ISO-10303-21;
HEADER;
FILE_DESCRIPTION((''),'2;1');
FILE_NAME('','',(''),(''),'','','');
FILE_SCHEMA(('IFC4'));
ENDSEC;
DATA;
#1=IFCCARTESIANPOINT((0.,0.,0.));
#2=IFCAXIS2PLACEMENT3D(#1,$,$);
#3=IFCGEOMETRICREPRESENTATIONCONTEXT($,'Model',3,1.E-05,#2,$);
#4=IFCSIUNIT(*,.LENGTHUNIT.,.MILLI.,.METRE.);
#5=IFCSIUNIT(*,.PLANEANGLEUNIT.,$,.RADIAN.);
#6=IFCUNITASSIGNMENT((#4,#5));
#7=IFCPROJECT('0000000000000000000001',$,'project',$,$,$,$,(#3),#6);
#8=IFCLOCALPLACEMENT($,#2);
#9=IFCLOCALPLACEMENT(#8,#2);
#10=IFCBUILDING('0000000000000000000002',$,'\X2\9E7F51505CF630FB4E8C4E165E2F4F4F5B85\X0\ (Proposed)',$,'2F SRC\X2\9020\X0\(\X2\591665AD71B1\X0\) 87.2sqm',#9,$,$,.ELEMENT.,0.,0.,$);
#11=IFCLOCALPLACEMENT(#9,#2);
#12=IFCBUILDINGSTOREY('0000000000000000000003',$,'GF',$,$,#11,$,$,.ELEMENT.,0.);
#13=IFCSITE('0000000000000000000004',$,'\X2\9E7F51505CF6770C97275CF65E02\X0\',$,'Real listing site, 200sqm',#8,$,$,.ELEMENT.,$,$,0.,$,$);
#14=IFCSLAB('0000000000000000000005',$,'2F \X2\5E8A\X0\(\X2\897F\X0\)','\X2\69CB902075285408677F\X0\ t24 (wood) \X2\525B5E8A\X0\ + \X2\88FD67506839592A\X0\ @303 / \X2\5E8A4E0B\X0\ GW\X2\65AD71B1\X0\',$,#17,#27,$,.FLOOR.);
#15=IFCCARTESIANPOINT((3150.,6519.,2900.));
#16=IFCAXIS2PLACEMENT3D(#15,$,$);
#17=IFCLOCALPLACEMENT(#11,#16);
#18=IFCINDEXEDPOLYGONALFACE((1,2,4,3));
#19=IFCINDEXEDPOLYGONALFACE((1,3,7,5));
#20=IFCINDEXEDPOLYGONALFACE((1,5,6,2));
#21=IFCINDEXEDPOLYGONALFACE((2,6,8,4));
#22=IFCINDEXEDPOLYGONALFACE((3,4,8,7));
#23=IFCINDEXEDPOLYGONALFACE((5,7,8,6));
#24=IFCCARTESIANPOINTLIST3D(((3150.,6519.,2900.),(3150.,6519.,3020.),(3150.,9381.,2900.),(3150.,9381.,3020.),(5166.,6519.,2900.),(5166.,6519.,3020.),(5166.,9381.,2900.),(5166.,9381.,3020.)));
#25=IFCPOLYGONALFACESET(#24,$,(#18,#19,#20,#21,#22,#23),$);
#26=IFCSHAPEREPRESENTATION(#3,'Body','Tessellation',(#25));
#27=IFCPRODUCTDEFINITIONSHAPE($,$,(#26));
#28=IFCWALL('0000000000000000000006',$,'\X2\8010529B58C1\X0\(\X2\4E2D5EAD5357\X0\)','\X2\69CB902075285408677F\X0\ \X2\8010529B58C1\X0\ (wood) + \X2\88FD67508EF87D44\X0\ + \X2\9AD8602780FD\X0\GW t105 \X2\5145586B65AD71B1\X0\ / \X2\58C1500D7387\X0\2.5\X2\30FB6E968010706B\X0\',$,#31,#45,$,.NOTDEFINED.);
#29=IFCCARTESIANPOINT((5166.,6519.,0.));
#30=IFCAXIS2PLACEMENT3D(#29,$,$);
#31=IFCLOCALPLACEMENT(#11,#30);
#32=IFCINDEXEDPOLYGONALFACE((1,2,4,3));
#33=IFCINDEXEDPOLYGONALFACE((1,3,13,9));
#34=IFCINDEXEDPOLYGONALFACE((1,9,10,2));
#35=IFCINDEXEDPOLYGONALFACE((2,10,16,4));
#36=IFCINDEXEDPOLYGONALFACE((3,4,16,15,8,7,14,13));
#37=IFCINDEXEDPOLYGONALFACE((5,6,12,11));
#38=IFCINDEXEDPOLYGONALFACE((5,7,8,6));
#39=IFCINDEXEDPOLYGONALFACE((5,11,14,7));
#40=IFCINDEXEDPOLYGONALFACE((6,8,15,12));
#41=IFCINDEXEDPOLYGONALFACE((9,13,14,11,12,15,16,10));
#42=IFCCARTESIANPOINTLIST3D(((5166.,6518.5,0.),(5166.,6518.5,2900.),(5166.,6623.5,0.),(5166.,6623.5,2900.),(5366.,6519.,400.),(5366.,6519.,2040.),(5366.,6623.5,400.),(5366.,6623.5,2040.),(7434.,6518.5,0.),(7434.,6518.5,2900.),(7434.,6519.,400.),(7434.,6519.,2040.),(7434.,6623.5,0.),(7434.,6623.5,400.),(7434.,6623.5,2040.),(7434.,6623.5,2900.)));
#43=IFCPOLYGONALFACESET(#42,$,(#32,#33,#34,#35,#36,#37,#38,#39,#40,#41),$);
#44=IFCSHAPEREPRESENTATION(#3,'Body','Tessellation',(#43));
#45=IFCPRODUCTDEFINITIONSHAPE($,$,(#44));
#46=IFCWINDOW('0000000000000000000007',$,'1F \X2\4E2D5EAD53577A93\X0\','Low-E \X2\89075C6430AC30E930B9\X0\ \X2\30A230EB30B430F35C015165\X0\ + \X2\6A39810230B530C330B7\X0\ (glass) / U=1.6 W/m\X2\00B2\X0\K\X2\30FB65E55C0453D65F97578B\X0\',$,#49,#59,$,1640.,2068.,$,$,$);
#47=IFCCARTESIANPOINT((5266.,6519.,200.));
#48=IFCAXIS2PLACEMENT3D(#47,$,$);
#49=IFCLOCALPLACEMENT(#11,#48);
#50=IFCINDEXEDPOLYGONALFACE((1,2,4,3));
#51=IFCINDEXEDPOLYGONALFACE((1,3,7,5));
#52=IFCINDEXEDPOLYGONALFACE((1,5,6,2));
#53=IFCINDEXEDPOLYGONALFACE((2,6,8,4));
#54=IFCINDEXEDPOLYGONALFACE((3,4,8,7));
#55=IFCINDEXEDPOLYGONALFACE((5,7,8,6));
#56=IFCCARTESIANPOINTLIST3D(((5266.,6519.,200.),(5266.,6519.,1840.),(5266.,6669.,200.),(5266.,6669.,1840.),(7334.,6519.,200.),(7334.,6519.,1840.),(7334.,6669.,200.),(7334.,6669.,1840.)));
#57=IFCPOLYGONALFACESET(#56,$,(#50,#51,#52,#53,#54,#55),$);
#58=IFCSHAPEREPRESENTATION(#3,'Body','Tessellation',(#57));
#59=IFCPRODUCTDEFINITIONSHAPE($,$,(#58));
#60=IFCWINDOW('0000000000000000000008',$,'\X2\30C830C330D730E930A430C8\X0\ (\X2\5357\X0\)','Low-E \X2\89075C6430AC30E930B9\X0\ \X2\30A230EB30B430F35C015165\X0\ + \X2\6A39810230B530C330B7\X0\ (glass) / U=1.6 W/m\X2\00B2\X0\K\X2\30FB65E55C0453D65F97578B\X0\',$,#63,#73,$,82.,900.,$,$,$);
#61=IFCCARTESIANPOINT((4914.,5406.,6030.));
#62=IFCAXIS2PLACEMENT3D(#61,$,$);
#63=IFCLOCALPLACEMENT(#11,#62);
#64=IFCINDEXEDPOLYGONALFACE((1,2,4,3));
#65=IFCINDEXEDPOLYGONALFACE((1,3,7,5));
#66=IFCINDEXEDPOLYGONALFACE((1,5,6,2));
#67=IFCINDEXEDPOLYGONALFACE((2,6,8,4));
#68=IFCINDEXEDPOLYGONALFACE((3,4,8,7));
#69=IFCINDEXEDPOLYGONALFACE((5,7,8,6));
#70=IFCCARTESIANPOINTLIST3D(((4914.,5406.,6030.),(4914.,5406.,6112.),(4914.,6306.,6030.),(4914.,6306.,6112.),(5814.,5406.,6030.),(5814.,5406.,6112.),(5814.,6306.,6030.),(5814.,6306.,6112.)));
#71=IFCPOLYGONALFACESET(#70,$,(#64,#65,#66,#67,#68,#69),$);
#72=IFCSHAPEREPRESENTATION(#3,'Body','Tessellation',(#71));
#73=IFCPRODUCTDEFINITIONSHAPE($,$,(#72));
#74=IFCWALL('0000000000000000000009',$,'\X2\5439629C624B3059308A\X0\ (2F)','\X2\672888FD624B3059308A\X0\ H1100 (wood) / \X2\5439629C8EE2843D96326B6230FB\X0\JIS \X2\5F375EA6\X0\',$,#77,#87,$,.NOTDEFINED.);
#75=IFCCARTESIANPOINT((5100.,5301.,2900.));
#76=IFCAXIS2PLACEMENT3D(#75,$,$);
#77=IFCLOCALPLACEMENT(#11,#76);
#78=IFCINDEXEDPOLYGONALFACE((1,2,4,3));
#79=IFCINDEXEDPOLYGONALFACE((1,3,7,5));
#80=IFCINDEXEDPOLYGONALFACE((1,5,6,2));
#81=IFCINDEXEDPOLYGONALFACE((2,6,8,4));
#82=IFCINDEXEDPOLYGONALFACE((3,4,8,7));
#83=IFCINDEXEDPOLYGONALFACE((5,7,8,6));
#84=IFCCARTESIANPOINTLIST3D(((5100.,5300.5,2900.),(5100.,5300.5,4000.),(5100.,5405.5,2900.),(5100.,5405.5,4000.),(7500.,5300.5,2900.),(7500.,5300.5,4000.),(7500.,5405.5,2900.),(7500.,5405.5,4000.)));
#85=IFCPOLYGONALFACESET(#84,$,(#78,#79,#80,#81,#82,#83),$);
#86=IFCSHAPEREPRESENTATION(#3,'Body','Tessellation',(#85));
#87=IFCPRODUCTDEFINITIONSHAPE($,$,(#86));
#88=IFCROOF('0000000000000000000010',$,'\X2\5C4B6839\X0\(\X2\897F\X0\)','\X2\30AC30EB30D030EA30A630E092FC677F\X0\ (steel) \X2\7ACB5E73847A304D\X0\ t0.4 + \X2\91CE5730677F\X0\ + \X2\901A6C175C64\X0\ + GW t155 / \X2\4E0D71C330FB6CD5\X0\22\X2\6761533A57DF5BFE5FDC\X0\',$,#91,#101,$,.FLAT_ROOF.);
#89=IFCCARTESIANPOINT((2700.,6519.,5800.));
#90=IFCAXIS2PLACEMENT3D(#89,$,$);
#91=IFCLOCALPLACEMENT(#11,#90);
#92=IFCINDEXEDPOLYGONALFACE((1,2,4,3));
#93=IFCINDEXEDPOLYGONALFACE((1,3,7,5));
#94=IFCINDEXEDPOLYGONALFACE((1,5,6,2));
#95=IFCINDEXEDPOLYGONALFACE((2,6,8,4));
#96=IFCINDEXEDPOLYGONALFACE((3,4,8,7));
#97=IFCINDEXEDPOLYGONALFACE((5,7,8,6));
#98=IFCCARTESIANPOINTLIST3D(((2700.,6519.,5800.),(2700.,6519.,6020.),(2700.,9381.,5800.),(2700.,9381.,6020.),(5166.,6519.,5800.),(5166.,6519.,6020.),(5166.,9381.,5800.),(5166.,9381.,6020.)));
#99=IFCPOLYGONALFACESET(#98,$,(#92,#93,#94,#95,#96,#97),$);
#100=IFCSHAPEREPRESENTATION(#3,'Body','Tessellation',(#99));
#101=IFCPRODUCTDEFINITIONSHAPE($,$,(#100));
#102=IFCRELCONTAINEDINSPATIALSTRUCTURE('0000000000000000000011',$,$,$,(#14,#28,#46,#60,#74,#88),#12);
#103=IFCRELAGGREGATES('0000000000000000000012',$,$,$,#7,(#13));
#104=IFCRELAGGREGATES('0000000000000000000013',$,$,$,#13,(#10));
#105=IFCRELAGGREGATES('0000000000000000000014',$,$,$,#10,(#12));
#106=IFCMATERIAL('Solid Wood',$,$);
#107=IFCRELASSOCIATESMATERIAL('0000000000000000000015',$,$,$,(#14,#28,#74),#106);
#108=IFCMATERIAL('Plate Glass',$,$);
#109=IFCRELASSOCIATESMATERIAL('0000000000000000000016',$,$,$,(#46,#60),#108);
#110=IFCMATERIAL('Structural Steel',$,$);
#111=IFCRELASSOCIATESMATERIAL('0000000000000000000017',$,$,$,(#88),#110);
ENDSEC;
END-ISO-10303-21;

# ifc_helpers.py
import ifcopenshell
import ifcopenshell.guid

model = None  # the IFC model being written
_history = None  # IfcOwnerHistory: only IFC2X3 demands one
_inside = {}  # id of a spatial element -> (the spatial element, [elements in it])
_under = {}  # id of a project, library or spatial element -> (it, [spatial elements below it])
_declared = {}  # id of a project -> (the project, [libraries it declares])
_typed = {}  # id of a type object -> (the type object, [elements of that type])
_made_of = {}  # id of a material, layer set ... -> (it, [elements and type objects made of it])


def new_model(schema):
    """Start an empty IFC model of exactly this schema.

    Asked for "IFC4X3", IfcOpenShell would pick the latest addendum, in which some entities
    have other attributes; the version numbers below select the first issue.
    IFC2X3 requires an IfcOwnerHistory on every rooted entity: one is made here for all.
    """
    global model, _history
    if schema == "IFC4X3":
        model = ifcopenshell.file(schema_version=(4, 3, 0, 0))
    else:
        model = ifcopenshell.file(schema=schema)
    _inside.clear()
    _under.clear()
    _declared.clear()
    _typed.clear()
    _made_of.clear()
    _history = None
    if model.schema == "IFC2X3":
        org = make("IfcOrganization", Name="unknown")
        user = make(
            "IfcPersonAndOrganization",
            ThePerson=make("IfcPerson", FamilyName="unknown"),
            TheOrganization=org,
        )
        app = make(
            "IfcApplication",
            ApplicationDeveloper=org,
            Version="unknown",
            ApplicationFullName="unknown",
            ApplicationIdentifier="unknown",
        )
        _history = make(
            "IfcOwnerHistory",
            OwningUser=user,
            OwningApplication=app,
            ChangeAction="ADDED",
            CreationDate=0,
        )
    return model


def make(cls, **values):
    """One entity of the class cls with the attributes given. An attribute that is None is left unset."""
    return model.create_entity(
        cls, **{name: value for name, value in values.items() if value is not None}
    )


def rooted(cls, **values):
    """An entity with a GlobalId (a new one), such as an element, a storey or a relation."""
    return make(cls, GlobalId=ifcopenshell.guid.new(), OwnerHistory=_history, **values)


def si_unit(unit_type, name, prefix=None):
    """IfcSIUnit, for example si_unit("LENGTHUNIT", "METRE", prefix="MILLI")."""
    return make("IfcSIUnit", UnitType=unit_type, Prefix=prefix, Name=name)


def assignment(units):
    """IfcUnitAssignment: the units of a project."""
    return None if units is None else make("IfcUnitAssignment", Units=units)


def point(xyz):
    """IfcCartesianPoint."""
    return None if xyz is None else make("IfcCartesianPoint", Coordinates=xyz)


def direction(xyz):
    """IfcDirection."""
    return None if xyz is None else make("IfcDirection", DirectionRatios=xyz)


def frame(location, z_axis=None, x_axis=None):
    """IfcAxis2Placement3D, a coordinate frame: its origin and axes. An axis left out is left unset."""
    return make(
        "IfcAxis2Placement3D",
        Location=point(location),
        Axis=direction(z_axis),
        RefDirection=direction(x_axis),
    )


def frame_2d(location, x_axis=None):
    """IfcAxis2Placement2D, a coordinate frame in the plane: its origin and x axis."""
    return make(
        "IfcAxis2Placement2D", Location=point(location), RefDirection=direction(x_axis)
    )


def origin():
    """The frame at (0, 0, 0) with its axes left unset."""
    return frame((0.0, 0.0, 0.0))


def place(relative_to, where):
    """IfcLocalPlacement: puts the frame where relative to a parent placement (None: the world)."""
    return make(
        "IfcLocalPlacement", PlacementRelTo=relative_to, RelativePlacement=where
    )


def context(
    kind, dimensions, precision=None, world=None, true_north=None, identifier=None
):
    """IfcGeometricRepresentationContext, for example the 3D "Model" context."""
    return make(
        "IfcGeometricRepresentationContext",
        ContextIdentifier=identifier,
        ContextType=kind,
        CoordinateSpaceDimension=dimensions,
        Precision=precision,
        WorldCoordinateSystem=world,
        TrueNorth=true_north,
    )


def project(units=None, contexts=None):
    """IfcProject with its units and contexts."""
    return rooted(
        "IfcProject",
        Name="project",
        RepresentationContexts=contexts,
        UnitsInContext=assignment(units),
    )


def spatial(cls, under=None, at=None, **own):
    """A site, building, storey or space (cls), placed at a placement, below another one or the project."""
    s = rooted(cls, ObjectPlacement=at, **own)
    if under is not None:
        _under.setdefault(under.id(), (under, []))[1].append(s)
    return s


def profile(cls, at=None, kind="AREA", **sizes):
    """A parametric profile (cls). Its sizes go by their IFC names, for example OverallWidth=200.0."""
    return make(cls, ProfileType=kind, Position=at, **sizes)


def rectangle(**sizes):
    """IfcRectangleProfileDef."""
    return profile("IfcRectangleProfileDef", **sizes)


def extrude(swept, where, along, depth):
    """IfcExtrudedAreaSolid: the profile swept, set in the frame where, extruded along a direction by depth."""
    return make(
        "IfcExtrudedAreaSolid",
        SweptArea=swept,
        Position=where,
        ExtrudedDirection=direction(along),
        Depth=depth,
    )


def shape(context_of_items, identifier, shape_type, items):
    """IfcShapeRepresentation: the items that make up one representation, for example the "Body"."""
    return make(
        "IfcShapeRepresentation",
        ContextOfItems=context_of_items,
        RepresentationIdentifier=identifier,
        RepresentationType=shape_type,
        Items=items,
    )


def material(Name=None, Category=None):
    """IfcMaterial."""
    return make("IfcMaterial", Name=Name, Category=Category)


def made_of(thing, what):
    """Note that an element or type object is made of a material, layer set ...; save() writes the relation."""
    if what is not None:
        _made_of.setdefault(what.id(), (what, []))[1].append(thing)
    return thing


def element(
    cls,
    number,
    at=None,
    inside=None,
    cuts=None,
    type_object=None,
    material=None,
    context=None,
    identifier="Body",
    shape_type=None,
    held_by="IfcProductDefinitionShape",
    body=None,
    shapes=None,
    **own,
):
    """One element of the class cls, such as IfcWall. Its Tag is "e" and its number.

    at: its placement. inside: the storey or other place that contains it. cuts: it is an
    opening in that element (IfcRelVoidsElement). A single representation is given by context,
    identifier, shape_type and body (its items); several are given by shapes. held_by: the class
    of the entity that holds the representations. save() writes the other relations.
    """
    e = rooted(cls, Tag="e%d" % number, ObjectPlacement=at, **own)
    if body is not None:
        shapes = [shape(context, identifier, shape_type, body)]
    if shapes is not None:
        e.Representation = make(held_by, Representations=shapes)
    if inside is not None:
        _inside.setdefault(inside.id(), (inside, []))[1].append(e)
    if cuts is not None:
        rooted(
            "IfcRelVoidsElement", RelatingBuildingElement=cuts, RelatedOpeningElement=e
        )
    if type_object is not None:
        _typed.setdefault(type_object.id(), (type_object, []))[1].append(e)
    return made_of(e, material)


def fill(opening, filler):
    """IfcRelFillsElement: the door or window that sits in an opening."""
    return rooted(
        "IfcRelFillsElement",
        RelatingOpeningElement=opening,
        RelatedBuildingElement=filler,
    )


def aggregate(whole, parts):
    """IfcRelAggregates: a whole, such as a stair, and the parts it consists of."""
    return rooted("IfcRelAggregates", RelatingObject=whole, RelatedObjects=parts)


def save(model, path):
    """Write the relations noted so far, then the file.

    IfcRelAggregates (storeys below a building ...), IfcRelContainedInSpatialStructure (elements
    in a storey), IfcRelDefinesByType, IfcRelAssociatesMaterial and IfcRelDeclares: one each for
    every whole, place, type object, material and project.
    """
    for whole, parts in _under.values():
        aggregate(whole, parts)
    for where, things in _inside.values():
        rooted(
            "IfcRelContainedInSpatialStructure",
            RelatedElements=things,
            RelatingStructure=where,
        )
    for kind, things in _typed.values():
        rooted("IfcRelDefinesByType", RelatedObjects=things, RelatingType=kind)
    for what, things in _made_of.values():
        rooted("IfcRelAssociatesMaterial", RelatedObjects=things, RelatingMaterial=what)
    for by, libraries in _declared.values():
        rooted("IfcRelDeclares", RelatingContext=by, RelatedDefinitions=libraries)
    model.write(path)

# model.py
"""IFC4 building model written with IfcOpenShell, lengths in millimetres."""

from ifc_helpers import new_model, si_unit, frame, frame_2d, origin, place, context, project, spatial, rectangle, extrude, material, element, fill, save


model = new_model("IFC4")

# Units and contexts
model_context = context("Model", 3, precision=1e-05, world=origin())
ifc_project = project(units=[si_unit("LENGTHUNIT", "METRE", prefix="MILLI"), si_unit("PLANEANGLEUNIT", "RADIAN")], contexts=[model_context])

# Site, building, storey
site_placement = place(None, origin())
site = spatial("IfcSite", under=ifc_project, at=site_placement, Name="鹿児島県霧島市", ObjectType="Real listing site, 200sqm", CompositionType="ELEMENT", RefElevation=0.0)
building_placement = place(site_placement, origin())
building = spatial("IfcBuilding", under=site, at=building_placement, Name="鹿児島・二世帯住宅 (Proposed)", ObjectType="2F SRC造(外断熱) 87.2sqm", CompositionType="ELEMENT", ElevationOfRefHeight=0.0, ElevationOfTerrain=0.0)
storey_placement = place(building_placement, origin())
storey = spatial("IfcBuildingStorey", under=building, at=storey_placement, Name="GF", CompositionType="ELEMENT", Elevation=0.0)

# Shared definitions
ifc_material_1 = material(Name="Solid Wood")

# Slab
slab_1_placement = place(storey_placement, frame((3150.0, 6519.0, 2900.0)))
element("IfcSlab", 1, at=slab_1_placement, inside=storey, material=ifc_material_1, Name="2F 床(西)", Description="構造用合板 t24 (wood) 剛床 + 製材根太 @303 / 床下 GW断熱", PredefinedType="FLOOR", context=model_context, shape_type="SweptSolid", body=[
    extrude(rectangle(XDim=2016.0, YDim=2862.0, at=frame_2d((1008.0, 1431.0))), frame((3150.0, 6519.0, 2900.0)), (0.0, 0.0, 1.0), 120.0),
])

# Wall, opening, window
wall_1_placement = place(storey_placement, frame((5166.0, 6519.0, 0.0)))
wall_1 = element("IfcWall", 2, at=wall_1_placement, inside=storey, material=ifc_material_1, Name="耐力壁(中庭南)", Description="構造用合板 耐力壁 (wood) + 製材軸組 + 高性能GW t105 充填断熱 / 壁倍率2.5・準耐火", PredefinedType="NOTDEFINED", context=model_context, shape_type="SweptSolid", body=[
    extrude(rectangle(XDim=2268.0, YDim=105.0, at=frame_2d((1134.0, 52.0))), frame((5166.0, 6519.0, 0.0)), (0.0, 0.0, 1.0), 2900.0),
])
opening_placement = place(storey_placement, frame((5266.0, 6519.0, 200.0)))
opening = element("IfcOpeningElement", 3, at=opening_placement, cuts=wall_1, PredefinedType="NOTDEFINED", context=model_context, shape_type="SweptSolid", body=[
    extrude(rectangle(XDim=2068.0, YDim=150.0, at=frame_2d((1034.0, 75.0))), frame((5266.0, 6519.0, 200.0)), (0.0, 0.0, 1.0), 1640.0),
])
ifc_material_2 = material(Name="Plate Glass")
window_1_placement = place(storey_placement, frame((5266.0, 6519.0, 200.0)))
window_1 = element("IfcWindow", 4, at=window_1_placement, inside=storey, material=ifc_material_2, Name="1F 中庭南窓", Description="Low-E 複層ガラス アルゴン封入 + 樹脂サッシ (glass) / U=1.6 W/m²K・日射取得型", OverallHeight=1640.0, OverallWidth=2068.0, context=model_context, shape_type="SweptSolid", body=[
    extrude(rectangle(XDim=2068.0, YDim=150.0, at=frame_2d((1034.0, 75.0))), frame((5266.0, 6519.0, 200.0)), (0.0, 0.0, 1.0), 1640.0),
])
fill(opening, window_1)

# Window
window_2_placement = place(storey_placement, frame((4914.0, 5406.0, 6030.0)))
element("IfcWindow", 5, at=window_2_placement, inside=storey, material=ifc_material_2, Name="トップライト (南)", Description="Low-E 複層ガラス アルゴン封入 + 樹脂サッシ (glass) / U=1.6 W/m²K・日射取得型", OverallHeight=82.0, OverallWidth=900.0, context=model_context, shape_type="SweptSolid", body=[
    extrude(rectangle(XDim=900.0, YDim=900.0, at=frame_2d((450.0, 450.0))), frame((4914.0, 5406.0, 6030.0)), (0.0, 0.0, 1.0), 82.0),
])

# Wall
wall_2_placement = place(storey_placement, frame((5100.0, 5301.0, 2900.0)))
element("IfcWall", 6, at=wall_2_placement, inside=storey, material=ifc_material_1, Name="吹抜手すり (2F)", Description="木製手すり H1100 (wood) / 吹抜転落防止・JIS 強度", PredefinedType="NOTDEFINED", context=model_context, shape_type="SweptSolid", body=[
    extrude(rectangle(XDim=2400.0, YDim=105.0, at=frame_2d((1200.0, 52.0))), frame((5100.0, 5301.0, 2900.0)), (0.0, 0.0, 1.0), 1100.0),
])

# Roof
ifc_material_3 = material(Name="Structural Steel")
for number, where, name in (
    (7, (2700.0, 6519.0, 5800.0), "屋根(西)"),
):
    element("IfcRoof", number, at=place(storey_placement, frame(where)), inside=storey, material=ifc_material_3, Name=name, Description="ガルバリウム鋼板 (steel) 立平葺き t0.4 + 野地板 + 通気層 + GW t155 / 不燃・法22条区域対応", PredefinedType="FLAT_ROOF", context=model_context, shape_type="SweptSolid", body=[
        extrude(rectangle(XDim=2466.0, YDim=2862.0, at=frame_2d((1233.0, 1431.0))), frame((2700.0, 6519.0, 5800.0)), (0.0, 0.0, 1.0), 220.0),
    ])

save(model, "model.ifc")
